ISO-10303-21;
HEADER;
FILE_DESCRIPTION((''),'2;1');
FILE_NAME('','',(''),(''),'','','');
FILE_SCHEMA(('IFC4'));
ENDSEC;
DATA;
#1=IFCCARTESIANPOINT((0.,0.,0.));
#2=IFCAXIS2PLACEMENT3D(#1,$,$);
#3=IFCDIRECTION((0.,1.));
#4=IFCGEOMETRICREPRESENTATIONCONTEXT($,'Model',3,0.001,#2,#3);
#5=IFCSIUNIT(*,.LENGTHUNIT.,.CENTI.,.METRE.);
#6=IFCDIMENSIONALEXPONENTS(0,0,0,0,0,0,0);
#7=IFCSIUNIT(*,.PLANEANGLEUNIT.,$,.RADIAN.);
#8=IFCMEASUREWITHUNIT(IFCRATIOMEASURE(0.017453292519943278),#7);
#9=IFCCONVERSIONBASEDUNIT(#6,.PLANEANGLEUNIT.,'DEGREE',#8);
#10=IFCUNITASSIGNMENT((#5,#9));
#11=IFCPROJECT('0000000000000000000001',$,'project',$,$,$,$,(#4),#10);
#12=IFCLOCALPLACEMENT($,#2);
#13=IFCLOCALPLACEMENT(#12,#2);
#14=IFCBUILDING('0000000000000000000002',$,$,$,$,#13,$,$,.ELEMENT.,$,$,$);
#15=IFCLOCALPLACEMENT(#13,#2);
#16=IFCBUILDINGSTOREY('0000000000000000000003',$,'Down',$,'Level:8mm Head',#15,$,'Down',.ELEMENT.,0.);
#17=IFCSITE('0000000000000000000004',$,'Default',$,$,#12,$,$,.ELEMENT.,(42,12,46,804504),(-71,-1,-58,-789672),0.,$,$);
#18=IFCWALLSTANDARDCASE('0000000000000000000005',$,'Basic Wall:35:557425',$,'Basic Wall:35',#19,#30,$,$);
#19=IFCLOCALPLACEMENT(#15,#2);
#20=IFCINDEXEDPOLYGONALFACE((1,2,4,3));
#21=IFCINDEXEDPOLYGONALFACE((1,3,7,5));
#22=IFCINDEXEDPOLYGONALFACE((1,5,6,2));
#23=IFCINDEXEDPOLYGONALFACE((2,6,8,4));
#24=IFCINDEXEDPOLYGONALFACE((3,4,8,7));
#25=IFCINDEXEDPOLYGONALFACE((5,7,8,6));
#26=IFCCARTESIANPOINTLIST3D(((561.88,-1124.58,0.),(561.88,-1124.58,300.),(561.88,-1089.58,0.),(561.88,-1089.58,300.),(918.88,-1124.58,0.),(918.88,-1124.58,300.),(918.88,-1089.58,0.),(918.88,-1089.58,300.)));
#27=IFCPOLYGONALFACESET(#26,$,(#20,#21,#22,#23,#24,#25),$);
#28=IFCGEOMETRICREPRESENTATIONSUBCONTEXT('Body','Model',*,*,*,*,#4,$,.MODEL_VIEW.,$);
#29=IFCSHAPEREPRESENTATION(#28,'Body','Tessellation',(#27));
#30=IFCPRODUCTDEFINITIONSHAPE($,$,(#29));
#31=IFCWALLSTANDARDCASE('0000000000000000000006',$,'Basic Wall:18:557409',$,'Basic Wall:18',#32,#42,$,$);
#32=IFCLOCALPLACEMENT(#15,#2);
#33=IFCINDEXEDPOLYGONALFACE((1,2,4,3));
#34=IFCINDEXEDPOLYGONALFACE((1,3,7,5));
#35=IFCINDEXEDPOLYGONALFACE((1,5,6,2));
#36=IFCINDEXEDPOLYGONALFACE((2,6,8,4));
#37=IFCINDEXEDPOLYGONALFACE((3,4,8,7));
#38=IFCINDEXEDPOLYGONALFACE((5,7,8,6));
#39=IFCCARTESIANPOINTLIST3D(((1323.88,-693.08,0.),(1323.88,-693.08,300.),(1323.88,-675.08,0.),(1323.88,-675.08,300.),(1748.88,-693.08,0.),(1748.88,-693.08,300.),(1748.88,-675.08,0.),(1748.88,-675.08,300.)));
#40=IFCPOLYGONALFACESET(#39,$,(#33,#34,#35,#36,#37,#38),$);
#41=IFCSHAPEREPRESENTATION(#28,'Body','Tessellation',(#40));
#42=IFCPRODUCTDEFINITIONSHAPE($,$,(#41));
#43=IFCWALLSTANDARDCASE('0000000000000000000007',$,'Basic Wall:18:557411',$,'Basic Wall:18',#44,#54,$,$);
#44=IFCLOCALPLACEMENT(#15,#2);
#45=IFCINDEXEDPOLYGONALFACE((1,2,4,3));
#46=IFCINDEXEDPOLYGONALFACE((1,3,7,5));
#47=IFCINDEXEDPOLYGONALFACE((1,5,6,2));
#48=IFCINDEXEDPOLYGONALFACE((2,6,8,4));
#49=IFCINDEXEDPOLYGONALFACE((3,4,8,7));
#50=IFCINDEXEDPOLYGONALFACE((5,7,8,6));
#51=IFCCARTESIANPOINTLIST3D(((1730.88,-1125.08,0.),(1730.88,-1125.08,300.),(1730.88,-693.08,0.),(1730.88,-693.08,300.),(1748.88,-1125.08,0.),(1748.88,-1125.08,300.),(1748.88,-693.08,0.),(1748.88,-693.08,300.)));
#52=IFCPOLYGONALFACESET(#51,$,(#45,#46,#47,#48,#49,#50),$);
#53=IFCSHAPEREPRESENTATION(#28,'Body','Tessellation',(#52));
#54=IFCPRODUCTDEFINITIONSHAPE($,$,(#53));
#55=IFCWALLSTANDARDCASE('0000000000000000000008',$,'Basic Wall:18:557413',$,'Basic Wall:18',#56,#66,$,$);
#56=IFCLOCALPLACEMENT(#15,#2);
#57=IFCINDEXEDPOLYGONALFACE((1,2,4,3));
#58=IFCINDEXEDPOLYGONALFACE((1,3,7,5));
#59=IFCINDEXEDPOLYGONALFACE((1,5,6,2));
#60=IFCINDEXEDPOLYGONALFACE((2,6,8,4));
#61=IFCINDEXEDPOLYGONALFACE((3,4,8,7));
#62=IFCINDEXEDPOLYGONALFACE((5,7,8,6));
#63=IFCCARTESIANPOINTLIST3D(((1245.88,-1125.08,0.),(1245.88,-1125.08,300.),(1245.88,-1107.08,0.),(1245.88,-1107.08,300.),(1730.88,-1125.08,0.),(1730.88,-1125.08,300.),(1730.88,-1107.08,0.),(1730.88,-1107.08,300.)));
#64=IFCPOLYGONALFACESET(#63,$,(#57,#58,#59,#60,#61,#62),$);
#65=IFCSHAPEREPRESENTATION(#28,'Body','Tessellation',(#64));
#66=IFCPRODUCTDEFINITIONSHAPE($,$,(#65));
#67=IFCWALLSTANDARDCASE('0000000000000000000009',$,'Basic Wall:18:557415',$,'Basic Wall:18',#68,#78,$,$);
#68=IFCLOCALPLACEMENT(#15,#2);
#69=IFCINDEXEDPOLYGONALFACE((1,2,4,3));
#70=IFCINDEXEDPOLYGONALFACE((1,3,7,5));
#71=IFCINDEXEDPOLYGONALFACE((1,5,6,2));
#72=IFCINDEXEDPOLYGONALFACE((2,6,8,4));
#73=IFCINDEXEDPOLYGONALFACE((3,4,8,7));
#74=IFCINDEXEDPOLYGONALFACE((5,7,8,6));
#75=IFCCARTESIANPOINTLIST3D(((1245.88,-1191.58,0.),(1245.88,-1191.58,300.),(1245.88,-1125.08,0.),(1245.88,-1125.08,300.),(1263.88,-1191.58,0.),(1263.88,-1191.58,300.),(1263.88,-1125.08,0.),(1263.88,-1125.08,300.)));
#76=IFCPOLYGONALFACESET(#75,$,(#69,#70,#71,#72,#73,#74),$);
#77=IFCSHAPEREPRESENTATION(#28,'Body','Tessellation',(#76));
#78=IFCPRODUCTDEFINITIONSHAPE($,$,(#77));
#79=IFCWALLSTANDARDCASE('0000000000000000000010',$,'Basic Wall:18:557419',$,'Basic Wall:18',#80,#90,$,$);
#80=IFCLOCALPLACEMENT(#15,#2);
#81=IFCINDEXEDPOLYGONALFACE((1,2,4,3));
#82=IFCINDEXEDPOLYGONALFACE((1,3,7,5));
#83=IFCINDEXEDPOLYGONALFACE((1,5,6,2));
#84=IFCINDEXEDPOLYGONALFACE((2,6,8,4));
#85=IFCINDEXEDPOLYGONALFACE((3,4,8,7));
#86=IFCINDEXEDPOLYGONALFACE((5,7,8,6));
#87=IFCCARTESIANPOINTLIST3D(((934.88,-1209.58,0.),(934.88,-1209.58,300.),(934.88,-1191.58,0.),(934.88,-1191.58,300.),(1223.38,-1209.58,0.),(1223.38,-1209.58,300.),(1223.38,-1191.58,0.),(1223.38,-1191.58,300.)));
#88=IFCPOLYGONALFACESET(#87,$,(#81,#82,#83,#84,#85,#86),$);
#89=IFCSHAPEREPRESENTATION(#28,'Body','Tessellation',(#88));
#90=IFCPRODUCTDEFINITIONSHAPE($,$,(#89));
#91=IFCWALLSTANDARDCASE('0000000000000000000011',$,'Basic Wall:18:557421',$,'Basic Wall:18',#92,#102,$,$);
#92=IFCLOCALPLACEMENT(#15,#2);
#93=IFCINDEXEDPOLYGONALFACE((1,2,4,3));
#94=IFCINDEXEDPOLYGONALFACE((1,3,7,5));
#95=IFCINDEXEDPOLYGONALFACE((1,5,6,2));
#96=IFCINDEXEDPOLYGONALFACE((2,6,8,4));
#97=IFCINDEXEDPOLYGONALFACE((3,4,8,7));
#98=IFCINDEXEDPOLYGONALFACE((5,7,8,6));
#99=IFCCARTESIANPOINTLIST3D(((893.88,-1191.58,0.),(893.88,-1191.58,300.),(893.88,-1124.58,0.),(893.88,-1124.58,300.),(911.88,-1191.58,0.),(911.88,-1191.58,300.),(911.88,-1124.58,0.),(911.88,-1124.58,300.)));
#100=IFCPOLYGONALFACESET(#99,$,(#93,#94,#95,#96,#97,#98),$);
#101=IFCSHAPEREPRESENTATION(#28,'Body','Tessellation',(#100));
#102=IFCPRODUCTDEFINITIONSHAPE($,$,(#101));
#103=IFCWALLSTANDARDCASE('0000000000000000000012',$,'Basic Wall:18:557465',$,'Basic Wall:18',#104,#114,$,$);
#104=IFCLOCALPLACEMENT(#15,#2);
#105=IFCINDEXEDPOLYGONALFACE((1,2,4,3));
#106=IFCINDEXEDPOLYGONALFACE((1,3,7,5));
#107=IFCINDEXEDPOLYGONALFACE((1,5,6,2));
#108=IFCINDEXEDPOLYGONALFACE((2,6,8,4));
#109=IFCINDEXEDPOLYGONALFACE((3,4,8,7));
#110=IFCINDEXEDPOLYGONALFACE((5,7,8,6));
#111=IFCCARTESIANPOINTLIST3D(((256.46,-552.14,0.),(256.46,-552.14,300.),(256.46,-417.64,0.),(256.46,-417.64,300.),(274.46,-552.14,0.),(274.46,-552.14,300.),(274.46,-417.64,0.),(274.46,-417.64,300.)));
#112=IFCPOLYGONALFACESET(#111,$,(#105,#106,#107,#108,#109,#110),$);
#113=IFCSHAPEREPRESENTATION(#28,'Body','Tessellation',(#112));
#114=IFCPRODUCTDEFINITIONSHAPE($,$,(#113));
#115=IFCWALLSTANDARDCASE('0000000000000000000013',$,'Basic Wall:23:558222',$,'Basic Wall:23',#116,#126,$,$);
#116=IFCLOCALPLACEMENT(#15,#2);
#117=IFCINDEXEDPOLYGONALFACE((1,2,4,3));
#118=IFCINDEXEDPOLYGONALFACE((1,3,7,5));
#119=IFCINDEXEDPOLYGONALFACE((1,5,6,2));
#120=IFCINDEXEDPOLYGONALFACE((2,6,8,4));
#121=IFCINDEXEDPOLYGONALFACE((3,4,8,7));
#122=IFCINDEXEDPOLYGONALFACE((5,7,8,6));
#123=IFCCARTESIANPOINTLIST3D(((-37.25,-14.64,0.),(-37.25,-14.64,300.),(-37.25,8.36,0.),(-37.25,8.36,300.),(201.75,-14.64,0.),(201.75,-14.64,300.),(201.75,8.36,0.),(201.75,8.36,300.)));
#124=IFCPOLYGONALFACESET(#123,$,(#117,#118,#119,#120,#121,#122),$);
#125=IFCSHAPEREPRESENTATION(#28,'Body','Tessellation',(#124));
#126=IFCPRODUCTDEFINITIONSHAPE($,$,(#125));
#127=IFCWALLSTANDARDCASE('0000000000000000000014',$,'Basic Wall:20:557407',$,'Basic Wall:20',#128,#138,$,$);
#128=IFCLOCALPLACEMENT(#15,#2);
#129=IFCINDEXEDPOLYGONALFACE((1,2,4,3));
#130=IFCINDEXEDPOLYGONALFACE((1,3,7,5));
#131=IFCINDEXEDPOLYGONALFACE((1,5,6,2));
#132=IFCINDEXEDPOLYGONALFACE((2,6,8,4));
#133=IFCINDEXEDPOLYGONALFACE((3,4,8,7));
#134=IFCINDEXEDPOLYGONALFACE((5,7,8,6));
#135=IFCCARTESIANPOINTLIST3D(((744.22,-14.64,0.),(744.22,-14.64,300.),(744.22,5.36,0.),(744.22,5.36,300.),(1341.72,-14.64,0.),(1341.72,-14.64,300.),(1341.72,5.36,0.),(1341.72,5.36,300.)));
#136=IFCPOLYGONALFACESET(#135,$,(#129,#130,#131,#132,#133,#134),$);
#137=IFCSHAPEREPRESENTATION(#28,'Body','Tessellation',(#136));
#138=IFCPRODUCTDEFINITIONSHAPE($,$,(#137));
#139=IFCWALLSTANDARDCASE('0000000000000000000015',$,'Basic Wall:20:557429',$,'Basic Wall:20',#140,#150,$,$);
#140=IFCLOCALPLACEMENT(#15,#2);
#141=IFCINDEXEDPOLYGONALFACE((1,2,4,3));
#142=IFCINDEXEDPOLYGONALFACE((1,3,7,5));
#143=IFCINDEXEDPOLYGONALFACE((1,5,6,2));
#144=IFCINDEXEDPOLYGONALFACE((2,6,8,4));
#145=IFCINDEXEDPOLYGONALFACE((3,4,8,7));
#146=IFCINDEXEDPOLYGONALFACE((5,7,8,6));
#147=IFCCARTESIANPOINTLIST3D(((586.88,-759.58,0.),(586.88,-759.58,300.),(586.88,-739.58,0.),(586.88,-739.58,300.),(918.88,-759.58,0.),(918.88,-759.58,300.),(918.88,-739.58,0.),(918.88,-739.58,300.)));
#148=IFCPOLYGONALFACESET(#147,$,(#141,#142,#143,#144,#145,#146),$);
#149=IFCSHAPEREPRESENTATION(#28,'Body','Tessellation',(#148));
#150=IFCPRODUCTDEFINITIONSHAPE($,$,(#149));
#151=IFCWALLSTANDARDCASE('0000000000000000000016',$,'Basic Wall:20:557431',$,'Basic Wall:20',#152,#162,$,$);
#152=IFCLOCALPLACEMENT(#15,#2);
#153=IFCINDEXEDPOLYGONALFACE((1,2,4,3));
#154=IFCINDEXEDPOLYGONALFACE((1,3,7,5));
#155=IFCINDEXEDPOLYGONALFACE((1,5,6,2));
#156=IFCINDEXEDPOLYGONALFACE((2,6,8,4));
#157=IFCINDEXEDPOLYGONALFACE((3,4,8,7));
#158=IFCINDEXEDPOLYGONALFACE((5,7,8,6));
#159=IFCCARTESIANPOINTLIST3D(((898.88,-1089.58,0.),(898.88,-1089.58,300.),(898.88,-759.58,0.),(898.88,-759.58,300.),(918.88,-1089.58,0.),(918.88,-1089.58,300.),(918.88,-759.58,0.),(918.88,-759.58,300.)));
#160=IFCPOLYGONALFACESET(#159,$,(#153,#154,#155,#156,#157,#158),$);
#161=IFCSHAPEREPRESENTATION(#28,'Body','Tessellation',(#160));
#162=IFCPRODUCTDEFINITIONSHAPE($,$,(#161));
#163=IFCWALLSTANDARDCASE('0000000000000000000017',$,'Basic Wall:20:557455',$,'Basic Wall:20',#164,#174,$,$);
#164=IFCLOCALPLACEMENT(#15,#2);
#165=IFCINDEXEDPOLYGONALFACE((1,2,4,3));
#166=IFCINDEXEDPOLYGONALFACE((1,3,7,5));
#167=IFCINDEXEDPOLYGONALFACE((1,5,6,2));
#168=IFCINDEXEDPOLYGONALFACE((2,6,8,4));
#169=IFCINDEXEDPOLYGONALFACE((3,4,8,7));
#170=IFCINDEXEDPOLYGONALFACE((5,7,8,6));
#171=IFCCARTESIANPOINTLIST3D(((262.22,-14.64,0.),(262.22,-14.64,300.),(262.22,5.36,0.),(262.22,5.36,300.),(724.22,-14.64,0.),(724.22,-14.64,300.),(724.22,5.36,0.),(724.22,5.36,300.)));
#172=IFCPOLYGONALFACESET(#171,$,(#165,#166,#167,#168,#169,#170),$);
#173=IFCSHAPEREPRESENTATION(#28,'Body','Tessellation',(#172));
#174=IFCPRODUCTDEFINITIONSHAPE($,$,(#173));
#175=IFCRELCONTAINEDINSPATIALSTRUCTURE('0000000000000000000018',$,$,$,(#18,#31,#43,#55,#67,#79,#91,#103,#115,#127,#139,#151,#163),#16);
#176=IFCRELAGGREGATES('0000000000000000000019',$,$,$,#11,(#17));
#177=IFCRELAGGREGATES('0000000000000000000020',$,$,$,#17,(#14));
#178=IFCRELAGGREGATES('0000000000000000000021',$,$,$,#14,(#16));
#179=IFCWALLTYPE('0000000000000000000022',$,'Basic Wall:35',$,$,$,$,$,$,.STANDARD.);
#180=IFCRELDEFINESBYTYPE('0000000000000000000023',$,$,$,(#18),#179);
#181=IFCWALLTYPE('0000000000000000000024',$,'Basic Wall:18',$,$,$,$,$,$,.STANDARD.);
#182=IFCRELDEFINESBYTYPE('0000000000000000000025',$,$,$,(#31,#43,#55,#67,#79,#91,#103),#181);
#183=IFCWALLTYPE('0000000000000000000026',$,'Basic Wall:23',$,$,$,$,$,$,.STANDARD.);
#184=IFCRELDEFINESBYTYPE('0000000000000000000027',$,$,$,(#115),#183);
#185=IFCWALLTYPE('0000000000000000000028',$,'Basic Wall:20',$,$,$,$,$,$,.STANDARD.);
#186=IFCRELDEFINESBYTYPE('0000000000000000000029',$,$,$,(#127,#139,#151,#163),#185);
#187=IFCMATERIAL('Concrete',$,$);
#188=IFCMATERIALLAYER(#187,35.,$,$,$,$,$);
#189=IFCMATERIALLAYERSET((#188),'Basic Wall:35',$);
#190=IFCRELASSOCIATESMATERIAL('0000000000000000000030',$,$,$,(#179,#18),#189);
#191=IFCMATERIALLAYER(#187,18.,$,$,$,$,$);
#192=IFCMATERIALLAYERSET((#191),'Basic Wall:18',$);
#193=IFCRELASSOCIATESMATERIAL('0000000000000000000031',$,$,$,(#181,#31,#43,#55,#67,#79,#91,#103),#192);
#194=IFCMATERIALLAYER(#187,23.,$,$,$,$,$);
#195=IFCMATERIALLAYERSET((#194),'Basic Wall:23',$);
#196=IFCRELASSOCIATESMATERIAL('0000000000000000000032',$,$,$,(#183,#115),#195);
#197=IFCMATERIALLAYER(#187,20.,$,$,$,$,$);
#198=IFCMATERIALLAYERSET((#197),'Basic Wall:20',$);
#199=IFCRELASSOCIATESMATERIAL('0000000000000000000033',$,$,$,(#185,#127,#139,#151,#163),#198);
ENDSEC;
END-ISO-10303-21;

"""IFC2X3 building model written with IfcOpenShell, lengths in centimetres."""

from ifc_helpers import new_model, entity, si_unit, converted_unit, direction, frame, frame_2d, origin, place, context, subcontext, project, spatial, rectangle, extrude, material, layer, layer_set, layer_usage, type_object, element, save


model = new_model("IFC2X3")

# Units and contexts
model_context = context("Model", 3, precision=0.001, world=origin(), true_north=direction((0.0, 1.0)))
body_context = subcontext(model_context, "Body", "Model", "MODEL_VIEW")
ifc_project = project(units=[si_unit("LENGTHUNIT", "METRE", prefix="CENTI"), converted_unit("PLANEANGLEUNIT", "DEGREE", entity("IfcRatioMeasure", 0.017453292519943278), si_unit("PLANEANGLEUNIT", "RADIAN"), dimensions=[0, 0, 0, 0, 0, 0, 0])], contexts=[model_context])

# Site, building, storey
site_placement = place(None, origin())
site = spatial("IfcSite", under=ifc_project, at=site_placement, Name="Default", CompositionType="ELEMENT", RefLatitude=(42, 12, 46, 804504), RefLongitude=(-71, -1, -58, -789672), RefElevation=0.0)
building_placement = place(site_placement, origin())
building = spatial("IfcBuilding", under=site, at=building_placement, CompositionType="ELEMENT")
storey_placement = place(building_placement, origin())
storey = spatial("IfcBuildingStorey", under=building, at=storey_placement, Name="Down", ObjectType="Level:8mm Head", LongName="Down", CompositionType="ELEMENT", Elevation=0.0)

# Walls
ifc_material = material(Name="Concrete")
ifc_layer_1 = layer(ifc_material, 35.0)
ifc_layer_set_1 = layer_set([ifc_layer_1], Name="Basic Wall:35")
ifc_layer_usage_1 = layer_usage(ifc_layer_set_1, "AXIS2", "NEGATIVE", 17.5)
wall_type_1 = type_object("IfcWallType", Name="Basic Wall:35", PredefinedType="STANDARD", material=ifc_layer_set_1)
wall_1_placement = place(storey_placement, frame((918.88, -1107.08, 0.0), z_axis=(0.0, 0.0, 1.0), x_axis=(-1.0, 0.0, 0.0)))
element("IfcWallStandardCase", 1, at=wall_1_placement, inside=storey, type_object=wall_type_1, material=ifc_layer_usage_1, Name="Basic Wall:35:557425", ObjectType="Basic Wall:35", context=body_context, shape_type="SweptSolid", body=[
    extrude(rectangle(XDim=357.0, YDim=35.0, at=frame_2d((178.5, 0.0), x_axis=(-1.0, 0.0))), origin(), (0.0, 0.0, 1.0), 300.0),
])
ifc_layer_2 = layer(ifc_material, 18.0)
ifc_layer_set_2 = layer_set([ifc_layer_2], Name="Basic Wall:18")
ifc_layer_usage_2 = layer_usage(ifc_layer_set_2, "AXIS2", "POSITIVE", -9.0)
wall_type_2 = type_object("IfcWallType", Name="Basic Wall:18", PredefinedType="STANDARD", material=ifc_layer_set_2)
wall_2_placement = place(storey_placement, frame((1323.88, -684.08, 0.0)))
element("IfcWallStandardCase", 2, at=wall_2_placement, inside=storey, type_object=wall_type_2, material=ifc_layer_usage_2, Name="Basic Wall:18:557409", ObjectType="Basic Wall:18", context=body_context, shape_type="SweptSolid", body=[
    extrude(rectangle(XDim=425.0, YDim=18.0, at=frame_2d((212.5, 0.0), x_axis=(-1.0, 0.0))), origin(), (0.0, 0.0, 1.0), 300.0),
])
ifc_layer_usage_3 = layer_usage(ifc_layer_set_2, "AXIS2", "NEGATIVE", 9.0)
wall_3_placement = place(storey_placement, frame((1739.88, -693.08, 0.0), z_axis=(0.0, 0.0, 1.0), x_axis=(0.0, -1.0, 0.0)))
element("IfcWallStandardCase", 3, at=wall_3_placement, inside=storey, type_object=wall_type_2, material=ifc_layer_usage_3, Name="Basic Wall:18:557411", ObjectType="Basic Wall:18", context=body_context, shape_type="SweptSolid", body=[
    extrude(rectangle(XDim=432.0, YDim=18.0, at=frame_2d((216.0, 0.0), x_axis=(-1.0, 0.0))), origin(), (0.0, 0.0, 1.0), 300.0),
])
ifc_layer_usage_4 = layer_usage(ifc_layer_set_2, "AXIS2", "NEGATIVE", 9.0)
wall_4_placement = place(storey_placement, frame((1730.88, -1116.08, 0.0), z_axis=(0.0, 0.0, 1.0), x_axis=(-1.0, 0.0, 0.0)))
element("IfcWallStandardCase", 4, at=wall_4_placement, inside=storey, type_object=wall_type_2, material=ifc_layer_usage_4, Name="Basic Wall:18:557413", ObjectType="Basic Wall:18", context=body_context, shape_type="SweptSolid", body=[
    extrude(rectangle(XDim=485.0, YDim=18.0, at=frame_2d((242.5, 0.0), x_axis=(-1.0, 0.0))), origin(), (0.0, 0.0, 1.0), 300.0),
])
ifc_layer_usage_5 = layer_usage(ifc_layer_set_2, "AXIS2", "POSITIVE", -9.0)
wall_5_placement = place(storey_placement, frame((1254.88, -1125.08, 0.0), z_axis=(0.0, 0.0, 1.0), x_axis=(0.0, -1.0, 0.0)))
element("IfcWallStandardCase", 5, at=wall_5_placement, inside=storey, type_object=wall_type_2, material=ifc_layer_usage_5, Name="Basic Wall:18:557415", ObjectType="Basic Wall:18", context=body_context, shape_type="SweptSolid", body=[
    extrude(rectangle(XDim=66.5, YDim=18.0, at=frame_2d((33.25, 0.0), x_axis=(-1.0, 0.0))), origin(), (0.0, 0.0, 1.0), 300.0),
])
ifc_layer_usage_6 = layer_usage(ifc_layer_set_2, "AXIS2", "POSITIVE", -9.0)
wall_6_placement = place(storey_placement, frame((1223.38, -1200.58, 0.0), z_axis=(0.0, 0.0, 1.0), x_axis=(-1.0, 0.0, 0.0)))
element("IfcWallStandardCase", 6, at=wall_6_placement, inside=storey, type_object=wall_type_2, material=ifc_layer_usage_6, Name="Basic Wall:18:557419", ObjectType="Basic Wall:18", context=body_context, shape_type="SweptSolid", body=[
    extrude(rectangle(XDim=288.5, YDim=18.0, at=frame_2d((144.25, 0.0), x_axis=(-1.0, 0.0))), origin(), (0.0, 0.0, 1.0), 300.0),
])
ifc_layer_usage_7 = layer_usage(ifc_layer_set_2, "AXIS2", "POSITIVE", -9.0)
wall_7_placement = place(storey_placement, frame((902.88, -1191.58, 0.0), z_axis=(0.0, 0.0, 1.0), x_axis=(0.0, 1.0, 0.0)))
element("IfcWallStandardCase", 7, at=wall_7_placement, inside=storey, type_object=wall_type_2, material=ifc_layer_usage_7, Name="Basic Wall:18:557421", ObjectType="Basic Wall:18", context=body_context, shape_type="SweptSolid", body=[
    extrude(rectangle(XDim=67.0, YDim=18.0, at=frame_2d((33.5, 0.0), x_axis=(-1.0, 0.0))), origin(), (0.0, 0.0, 1.0), 300.0),
])
ifc_layer_usage_8 = layer_usage(ifc_layer_set_2, "AXIS2", "NEGATIVE", 9.0)
wall_8_placement = place(storey_placement, frame((265.46, -417.64, 0.0), z_axis=(0.0, 0.0, 1.0), x_axis=(0.0, -1.0, 0.0)))
element("IfcWallStandardCase", 8, at=wall_8_placement, inside=storey, type_object=wall_type_2, material=ifc_layer_usage_8, Name="Basic Wall:18:557465", ObjectType="Basic Wall:18", context=body_context, shape_type="SweptSolid", body=[
    extrude(rectangle(XDim=134.5, YDim=18.0, at=frame_2d((67.25, 0.0), x_axis=(-1.0, 0.0))), origin(), (0.0, 0.0, 1.0), 300.0),
])
ifc_layer_3 = layer(ifc_material, 23.0)
ifc_layer_set_3 = layer_set([ifc_layer_3], Name="Basic Wall:23")
ifc_layer_usage_9 = layer_usage(ifc_layer_set_3, "AXIS2", "NEGATIVE", 11.5)
wall_type_3 = type_object("IfcWallType", Name="Basic Wall:23", PredefinedType="STANDARD", material=ifc_layer_set_3)
wall_9_placement = place(storey_placement, frame((201.75, -3.14, 0.0), z_axis=(0.0, 0.0, 1.0), x_axis=(-1.0, 0.0, 0.0)))
element("IfcWallStandardCase", 9, at=wall_9_placement, inside=storey, type_object=wall_type_3, material=ifc_layer_usage_9, Name="Basic Wall:23:558222", ObjectType="Basic Wall:23", context=body_context, shape_type="SweptSolid", body=[
    extrude(rectangle(XDim=239.0, YDim=23.0, at=frame_2d((119.5, 0.0), x_axis=(-1.0, 0.0))), origin(), (0.0, 0.0, 1.0), 300.0),
])
ifc_layer_4 = layer(ifc_material, 20.0)
ifc_layer_set_4 = layer_set([ifc_layer_4], Name="Basic Wall:20")
ifc_layer_usage_10 = layer_usage(ifc_layer_set_4, "AXIS2", "POSITIVE", -10.0)
wall_type_4 = type_object("IfcWallType", Name="Basic Wall:20", PredefinedType="STANDARD", material=ifc_layer_set_4)
wall_10_placement = place(storey_placement, frame((744.22, -4.64, 0.0)))
element("IfcWallStandardCase", 10, at=wall_10_placement, inside=storey, type_object=wall_type_4, material=ifc_layer_usage_10, Name="Basic Wall:20:557407", ObjectType="Basic Wall:20", context=body_context, shape_type="SweptSolid", body=[
    extrude(rectangle(XDim=597.5, YDim=20.0, at=frame_2d((298.75, 0.0), x_axis=(-1.0, 0.0))), origin(), (0.0, 0.0, 1.0), 300.0),
])
ifc_layer_usage_11 = layer_usage(ifc_layer_set_4, "AXIS2", "NEGATIVE", 10.0)
wall_11_placement = place(storey_placement, frame((586.88, -749.58, 0.0)))
element("IfcWallStandardCase", 11, at=wall_11_placement, inside=storey, type_object=wall_type_4, material=ifc_layer_usage_11, Name="Basic Wall:20:557429", ObjectType="Basic Wall:20", context=body_context, shape_type="SweptSolid", body=[
    extrude(rectangle(XDim=332.0, YDim=20.0, at=frame_2d((166.0, 0.0), x_axis=(-1.0, 0.0))), origin(), (0.0, 0.0, 1.0), 300.0),
])
ifc_layer_usage_12 = layer_usage(ifc_layer_set_4, "AXIS2", "NEGATIVE", 10.0)
wall_12_placement = place(storey_placement, frame((908.88, -759.58, 0.0), z_axis=(0.0, 0.0, 1.0), x_axis=(0.0, -1.0, 0.0)))
element("IfcWallStandardCase", 12, at=wall_12_placement, inside=storey, type_object=wall_type_4, material=ifc_layer_usage_12, Name="Basic Wall:20:557431", ObjectType="Basic Wall:20", context=body_context, shape_type="SweptSolid", body=[
    extrude(rectangle(XDim=330.0, YDim=20.0, at=frame_2d((165.0, 0.0), x_axis=(-1.0, 0.0))), origin(), (0.0, 0.0, 1.0), 300.0),
])
ifc_layer_usage_13 = layer_usage(ifc_layer_set_4, "AXIS2", "NEGATIVE", 10.0)
wall_13_placement = place(storey_placement, frame((724.22, -4.64, 0.0), z_axis=(0.0, 0.0, 1.0), x_axis=(-1.0, 0.0, 0.0)))
element("IfcWallStandardCase", 13, at=wall_13_placement, inside=storey, type_object=wall_type_4, material=ifc_layer_usage_13, Name="Basic Wall:20:557455", ObjectType="Basic Wall:20", context=body_context, shape_type="SweptSolid", body=[
    extrude(rectangle(XDim=462.0, YDim=20.0, at=frame_2d((231.0, 0.0), x_axis=(-1.0, 0.0))), origin(), (0.0, 0.0, 1.0), 300.0),
])

save(model, "model.ifc")
